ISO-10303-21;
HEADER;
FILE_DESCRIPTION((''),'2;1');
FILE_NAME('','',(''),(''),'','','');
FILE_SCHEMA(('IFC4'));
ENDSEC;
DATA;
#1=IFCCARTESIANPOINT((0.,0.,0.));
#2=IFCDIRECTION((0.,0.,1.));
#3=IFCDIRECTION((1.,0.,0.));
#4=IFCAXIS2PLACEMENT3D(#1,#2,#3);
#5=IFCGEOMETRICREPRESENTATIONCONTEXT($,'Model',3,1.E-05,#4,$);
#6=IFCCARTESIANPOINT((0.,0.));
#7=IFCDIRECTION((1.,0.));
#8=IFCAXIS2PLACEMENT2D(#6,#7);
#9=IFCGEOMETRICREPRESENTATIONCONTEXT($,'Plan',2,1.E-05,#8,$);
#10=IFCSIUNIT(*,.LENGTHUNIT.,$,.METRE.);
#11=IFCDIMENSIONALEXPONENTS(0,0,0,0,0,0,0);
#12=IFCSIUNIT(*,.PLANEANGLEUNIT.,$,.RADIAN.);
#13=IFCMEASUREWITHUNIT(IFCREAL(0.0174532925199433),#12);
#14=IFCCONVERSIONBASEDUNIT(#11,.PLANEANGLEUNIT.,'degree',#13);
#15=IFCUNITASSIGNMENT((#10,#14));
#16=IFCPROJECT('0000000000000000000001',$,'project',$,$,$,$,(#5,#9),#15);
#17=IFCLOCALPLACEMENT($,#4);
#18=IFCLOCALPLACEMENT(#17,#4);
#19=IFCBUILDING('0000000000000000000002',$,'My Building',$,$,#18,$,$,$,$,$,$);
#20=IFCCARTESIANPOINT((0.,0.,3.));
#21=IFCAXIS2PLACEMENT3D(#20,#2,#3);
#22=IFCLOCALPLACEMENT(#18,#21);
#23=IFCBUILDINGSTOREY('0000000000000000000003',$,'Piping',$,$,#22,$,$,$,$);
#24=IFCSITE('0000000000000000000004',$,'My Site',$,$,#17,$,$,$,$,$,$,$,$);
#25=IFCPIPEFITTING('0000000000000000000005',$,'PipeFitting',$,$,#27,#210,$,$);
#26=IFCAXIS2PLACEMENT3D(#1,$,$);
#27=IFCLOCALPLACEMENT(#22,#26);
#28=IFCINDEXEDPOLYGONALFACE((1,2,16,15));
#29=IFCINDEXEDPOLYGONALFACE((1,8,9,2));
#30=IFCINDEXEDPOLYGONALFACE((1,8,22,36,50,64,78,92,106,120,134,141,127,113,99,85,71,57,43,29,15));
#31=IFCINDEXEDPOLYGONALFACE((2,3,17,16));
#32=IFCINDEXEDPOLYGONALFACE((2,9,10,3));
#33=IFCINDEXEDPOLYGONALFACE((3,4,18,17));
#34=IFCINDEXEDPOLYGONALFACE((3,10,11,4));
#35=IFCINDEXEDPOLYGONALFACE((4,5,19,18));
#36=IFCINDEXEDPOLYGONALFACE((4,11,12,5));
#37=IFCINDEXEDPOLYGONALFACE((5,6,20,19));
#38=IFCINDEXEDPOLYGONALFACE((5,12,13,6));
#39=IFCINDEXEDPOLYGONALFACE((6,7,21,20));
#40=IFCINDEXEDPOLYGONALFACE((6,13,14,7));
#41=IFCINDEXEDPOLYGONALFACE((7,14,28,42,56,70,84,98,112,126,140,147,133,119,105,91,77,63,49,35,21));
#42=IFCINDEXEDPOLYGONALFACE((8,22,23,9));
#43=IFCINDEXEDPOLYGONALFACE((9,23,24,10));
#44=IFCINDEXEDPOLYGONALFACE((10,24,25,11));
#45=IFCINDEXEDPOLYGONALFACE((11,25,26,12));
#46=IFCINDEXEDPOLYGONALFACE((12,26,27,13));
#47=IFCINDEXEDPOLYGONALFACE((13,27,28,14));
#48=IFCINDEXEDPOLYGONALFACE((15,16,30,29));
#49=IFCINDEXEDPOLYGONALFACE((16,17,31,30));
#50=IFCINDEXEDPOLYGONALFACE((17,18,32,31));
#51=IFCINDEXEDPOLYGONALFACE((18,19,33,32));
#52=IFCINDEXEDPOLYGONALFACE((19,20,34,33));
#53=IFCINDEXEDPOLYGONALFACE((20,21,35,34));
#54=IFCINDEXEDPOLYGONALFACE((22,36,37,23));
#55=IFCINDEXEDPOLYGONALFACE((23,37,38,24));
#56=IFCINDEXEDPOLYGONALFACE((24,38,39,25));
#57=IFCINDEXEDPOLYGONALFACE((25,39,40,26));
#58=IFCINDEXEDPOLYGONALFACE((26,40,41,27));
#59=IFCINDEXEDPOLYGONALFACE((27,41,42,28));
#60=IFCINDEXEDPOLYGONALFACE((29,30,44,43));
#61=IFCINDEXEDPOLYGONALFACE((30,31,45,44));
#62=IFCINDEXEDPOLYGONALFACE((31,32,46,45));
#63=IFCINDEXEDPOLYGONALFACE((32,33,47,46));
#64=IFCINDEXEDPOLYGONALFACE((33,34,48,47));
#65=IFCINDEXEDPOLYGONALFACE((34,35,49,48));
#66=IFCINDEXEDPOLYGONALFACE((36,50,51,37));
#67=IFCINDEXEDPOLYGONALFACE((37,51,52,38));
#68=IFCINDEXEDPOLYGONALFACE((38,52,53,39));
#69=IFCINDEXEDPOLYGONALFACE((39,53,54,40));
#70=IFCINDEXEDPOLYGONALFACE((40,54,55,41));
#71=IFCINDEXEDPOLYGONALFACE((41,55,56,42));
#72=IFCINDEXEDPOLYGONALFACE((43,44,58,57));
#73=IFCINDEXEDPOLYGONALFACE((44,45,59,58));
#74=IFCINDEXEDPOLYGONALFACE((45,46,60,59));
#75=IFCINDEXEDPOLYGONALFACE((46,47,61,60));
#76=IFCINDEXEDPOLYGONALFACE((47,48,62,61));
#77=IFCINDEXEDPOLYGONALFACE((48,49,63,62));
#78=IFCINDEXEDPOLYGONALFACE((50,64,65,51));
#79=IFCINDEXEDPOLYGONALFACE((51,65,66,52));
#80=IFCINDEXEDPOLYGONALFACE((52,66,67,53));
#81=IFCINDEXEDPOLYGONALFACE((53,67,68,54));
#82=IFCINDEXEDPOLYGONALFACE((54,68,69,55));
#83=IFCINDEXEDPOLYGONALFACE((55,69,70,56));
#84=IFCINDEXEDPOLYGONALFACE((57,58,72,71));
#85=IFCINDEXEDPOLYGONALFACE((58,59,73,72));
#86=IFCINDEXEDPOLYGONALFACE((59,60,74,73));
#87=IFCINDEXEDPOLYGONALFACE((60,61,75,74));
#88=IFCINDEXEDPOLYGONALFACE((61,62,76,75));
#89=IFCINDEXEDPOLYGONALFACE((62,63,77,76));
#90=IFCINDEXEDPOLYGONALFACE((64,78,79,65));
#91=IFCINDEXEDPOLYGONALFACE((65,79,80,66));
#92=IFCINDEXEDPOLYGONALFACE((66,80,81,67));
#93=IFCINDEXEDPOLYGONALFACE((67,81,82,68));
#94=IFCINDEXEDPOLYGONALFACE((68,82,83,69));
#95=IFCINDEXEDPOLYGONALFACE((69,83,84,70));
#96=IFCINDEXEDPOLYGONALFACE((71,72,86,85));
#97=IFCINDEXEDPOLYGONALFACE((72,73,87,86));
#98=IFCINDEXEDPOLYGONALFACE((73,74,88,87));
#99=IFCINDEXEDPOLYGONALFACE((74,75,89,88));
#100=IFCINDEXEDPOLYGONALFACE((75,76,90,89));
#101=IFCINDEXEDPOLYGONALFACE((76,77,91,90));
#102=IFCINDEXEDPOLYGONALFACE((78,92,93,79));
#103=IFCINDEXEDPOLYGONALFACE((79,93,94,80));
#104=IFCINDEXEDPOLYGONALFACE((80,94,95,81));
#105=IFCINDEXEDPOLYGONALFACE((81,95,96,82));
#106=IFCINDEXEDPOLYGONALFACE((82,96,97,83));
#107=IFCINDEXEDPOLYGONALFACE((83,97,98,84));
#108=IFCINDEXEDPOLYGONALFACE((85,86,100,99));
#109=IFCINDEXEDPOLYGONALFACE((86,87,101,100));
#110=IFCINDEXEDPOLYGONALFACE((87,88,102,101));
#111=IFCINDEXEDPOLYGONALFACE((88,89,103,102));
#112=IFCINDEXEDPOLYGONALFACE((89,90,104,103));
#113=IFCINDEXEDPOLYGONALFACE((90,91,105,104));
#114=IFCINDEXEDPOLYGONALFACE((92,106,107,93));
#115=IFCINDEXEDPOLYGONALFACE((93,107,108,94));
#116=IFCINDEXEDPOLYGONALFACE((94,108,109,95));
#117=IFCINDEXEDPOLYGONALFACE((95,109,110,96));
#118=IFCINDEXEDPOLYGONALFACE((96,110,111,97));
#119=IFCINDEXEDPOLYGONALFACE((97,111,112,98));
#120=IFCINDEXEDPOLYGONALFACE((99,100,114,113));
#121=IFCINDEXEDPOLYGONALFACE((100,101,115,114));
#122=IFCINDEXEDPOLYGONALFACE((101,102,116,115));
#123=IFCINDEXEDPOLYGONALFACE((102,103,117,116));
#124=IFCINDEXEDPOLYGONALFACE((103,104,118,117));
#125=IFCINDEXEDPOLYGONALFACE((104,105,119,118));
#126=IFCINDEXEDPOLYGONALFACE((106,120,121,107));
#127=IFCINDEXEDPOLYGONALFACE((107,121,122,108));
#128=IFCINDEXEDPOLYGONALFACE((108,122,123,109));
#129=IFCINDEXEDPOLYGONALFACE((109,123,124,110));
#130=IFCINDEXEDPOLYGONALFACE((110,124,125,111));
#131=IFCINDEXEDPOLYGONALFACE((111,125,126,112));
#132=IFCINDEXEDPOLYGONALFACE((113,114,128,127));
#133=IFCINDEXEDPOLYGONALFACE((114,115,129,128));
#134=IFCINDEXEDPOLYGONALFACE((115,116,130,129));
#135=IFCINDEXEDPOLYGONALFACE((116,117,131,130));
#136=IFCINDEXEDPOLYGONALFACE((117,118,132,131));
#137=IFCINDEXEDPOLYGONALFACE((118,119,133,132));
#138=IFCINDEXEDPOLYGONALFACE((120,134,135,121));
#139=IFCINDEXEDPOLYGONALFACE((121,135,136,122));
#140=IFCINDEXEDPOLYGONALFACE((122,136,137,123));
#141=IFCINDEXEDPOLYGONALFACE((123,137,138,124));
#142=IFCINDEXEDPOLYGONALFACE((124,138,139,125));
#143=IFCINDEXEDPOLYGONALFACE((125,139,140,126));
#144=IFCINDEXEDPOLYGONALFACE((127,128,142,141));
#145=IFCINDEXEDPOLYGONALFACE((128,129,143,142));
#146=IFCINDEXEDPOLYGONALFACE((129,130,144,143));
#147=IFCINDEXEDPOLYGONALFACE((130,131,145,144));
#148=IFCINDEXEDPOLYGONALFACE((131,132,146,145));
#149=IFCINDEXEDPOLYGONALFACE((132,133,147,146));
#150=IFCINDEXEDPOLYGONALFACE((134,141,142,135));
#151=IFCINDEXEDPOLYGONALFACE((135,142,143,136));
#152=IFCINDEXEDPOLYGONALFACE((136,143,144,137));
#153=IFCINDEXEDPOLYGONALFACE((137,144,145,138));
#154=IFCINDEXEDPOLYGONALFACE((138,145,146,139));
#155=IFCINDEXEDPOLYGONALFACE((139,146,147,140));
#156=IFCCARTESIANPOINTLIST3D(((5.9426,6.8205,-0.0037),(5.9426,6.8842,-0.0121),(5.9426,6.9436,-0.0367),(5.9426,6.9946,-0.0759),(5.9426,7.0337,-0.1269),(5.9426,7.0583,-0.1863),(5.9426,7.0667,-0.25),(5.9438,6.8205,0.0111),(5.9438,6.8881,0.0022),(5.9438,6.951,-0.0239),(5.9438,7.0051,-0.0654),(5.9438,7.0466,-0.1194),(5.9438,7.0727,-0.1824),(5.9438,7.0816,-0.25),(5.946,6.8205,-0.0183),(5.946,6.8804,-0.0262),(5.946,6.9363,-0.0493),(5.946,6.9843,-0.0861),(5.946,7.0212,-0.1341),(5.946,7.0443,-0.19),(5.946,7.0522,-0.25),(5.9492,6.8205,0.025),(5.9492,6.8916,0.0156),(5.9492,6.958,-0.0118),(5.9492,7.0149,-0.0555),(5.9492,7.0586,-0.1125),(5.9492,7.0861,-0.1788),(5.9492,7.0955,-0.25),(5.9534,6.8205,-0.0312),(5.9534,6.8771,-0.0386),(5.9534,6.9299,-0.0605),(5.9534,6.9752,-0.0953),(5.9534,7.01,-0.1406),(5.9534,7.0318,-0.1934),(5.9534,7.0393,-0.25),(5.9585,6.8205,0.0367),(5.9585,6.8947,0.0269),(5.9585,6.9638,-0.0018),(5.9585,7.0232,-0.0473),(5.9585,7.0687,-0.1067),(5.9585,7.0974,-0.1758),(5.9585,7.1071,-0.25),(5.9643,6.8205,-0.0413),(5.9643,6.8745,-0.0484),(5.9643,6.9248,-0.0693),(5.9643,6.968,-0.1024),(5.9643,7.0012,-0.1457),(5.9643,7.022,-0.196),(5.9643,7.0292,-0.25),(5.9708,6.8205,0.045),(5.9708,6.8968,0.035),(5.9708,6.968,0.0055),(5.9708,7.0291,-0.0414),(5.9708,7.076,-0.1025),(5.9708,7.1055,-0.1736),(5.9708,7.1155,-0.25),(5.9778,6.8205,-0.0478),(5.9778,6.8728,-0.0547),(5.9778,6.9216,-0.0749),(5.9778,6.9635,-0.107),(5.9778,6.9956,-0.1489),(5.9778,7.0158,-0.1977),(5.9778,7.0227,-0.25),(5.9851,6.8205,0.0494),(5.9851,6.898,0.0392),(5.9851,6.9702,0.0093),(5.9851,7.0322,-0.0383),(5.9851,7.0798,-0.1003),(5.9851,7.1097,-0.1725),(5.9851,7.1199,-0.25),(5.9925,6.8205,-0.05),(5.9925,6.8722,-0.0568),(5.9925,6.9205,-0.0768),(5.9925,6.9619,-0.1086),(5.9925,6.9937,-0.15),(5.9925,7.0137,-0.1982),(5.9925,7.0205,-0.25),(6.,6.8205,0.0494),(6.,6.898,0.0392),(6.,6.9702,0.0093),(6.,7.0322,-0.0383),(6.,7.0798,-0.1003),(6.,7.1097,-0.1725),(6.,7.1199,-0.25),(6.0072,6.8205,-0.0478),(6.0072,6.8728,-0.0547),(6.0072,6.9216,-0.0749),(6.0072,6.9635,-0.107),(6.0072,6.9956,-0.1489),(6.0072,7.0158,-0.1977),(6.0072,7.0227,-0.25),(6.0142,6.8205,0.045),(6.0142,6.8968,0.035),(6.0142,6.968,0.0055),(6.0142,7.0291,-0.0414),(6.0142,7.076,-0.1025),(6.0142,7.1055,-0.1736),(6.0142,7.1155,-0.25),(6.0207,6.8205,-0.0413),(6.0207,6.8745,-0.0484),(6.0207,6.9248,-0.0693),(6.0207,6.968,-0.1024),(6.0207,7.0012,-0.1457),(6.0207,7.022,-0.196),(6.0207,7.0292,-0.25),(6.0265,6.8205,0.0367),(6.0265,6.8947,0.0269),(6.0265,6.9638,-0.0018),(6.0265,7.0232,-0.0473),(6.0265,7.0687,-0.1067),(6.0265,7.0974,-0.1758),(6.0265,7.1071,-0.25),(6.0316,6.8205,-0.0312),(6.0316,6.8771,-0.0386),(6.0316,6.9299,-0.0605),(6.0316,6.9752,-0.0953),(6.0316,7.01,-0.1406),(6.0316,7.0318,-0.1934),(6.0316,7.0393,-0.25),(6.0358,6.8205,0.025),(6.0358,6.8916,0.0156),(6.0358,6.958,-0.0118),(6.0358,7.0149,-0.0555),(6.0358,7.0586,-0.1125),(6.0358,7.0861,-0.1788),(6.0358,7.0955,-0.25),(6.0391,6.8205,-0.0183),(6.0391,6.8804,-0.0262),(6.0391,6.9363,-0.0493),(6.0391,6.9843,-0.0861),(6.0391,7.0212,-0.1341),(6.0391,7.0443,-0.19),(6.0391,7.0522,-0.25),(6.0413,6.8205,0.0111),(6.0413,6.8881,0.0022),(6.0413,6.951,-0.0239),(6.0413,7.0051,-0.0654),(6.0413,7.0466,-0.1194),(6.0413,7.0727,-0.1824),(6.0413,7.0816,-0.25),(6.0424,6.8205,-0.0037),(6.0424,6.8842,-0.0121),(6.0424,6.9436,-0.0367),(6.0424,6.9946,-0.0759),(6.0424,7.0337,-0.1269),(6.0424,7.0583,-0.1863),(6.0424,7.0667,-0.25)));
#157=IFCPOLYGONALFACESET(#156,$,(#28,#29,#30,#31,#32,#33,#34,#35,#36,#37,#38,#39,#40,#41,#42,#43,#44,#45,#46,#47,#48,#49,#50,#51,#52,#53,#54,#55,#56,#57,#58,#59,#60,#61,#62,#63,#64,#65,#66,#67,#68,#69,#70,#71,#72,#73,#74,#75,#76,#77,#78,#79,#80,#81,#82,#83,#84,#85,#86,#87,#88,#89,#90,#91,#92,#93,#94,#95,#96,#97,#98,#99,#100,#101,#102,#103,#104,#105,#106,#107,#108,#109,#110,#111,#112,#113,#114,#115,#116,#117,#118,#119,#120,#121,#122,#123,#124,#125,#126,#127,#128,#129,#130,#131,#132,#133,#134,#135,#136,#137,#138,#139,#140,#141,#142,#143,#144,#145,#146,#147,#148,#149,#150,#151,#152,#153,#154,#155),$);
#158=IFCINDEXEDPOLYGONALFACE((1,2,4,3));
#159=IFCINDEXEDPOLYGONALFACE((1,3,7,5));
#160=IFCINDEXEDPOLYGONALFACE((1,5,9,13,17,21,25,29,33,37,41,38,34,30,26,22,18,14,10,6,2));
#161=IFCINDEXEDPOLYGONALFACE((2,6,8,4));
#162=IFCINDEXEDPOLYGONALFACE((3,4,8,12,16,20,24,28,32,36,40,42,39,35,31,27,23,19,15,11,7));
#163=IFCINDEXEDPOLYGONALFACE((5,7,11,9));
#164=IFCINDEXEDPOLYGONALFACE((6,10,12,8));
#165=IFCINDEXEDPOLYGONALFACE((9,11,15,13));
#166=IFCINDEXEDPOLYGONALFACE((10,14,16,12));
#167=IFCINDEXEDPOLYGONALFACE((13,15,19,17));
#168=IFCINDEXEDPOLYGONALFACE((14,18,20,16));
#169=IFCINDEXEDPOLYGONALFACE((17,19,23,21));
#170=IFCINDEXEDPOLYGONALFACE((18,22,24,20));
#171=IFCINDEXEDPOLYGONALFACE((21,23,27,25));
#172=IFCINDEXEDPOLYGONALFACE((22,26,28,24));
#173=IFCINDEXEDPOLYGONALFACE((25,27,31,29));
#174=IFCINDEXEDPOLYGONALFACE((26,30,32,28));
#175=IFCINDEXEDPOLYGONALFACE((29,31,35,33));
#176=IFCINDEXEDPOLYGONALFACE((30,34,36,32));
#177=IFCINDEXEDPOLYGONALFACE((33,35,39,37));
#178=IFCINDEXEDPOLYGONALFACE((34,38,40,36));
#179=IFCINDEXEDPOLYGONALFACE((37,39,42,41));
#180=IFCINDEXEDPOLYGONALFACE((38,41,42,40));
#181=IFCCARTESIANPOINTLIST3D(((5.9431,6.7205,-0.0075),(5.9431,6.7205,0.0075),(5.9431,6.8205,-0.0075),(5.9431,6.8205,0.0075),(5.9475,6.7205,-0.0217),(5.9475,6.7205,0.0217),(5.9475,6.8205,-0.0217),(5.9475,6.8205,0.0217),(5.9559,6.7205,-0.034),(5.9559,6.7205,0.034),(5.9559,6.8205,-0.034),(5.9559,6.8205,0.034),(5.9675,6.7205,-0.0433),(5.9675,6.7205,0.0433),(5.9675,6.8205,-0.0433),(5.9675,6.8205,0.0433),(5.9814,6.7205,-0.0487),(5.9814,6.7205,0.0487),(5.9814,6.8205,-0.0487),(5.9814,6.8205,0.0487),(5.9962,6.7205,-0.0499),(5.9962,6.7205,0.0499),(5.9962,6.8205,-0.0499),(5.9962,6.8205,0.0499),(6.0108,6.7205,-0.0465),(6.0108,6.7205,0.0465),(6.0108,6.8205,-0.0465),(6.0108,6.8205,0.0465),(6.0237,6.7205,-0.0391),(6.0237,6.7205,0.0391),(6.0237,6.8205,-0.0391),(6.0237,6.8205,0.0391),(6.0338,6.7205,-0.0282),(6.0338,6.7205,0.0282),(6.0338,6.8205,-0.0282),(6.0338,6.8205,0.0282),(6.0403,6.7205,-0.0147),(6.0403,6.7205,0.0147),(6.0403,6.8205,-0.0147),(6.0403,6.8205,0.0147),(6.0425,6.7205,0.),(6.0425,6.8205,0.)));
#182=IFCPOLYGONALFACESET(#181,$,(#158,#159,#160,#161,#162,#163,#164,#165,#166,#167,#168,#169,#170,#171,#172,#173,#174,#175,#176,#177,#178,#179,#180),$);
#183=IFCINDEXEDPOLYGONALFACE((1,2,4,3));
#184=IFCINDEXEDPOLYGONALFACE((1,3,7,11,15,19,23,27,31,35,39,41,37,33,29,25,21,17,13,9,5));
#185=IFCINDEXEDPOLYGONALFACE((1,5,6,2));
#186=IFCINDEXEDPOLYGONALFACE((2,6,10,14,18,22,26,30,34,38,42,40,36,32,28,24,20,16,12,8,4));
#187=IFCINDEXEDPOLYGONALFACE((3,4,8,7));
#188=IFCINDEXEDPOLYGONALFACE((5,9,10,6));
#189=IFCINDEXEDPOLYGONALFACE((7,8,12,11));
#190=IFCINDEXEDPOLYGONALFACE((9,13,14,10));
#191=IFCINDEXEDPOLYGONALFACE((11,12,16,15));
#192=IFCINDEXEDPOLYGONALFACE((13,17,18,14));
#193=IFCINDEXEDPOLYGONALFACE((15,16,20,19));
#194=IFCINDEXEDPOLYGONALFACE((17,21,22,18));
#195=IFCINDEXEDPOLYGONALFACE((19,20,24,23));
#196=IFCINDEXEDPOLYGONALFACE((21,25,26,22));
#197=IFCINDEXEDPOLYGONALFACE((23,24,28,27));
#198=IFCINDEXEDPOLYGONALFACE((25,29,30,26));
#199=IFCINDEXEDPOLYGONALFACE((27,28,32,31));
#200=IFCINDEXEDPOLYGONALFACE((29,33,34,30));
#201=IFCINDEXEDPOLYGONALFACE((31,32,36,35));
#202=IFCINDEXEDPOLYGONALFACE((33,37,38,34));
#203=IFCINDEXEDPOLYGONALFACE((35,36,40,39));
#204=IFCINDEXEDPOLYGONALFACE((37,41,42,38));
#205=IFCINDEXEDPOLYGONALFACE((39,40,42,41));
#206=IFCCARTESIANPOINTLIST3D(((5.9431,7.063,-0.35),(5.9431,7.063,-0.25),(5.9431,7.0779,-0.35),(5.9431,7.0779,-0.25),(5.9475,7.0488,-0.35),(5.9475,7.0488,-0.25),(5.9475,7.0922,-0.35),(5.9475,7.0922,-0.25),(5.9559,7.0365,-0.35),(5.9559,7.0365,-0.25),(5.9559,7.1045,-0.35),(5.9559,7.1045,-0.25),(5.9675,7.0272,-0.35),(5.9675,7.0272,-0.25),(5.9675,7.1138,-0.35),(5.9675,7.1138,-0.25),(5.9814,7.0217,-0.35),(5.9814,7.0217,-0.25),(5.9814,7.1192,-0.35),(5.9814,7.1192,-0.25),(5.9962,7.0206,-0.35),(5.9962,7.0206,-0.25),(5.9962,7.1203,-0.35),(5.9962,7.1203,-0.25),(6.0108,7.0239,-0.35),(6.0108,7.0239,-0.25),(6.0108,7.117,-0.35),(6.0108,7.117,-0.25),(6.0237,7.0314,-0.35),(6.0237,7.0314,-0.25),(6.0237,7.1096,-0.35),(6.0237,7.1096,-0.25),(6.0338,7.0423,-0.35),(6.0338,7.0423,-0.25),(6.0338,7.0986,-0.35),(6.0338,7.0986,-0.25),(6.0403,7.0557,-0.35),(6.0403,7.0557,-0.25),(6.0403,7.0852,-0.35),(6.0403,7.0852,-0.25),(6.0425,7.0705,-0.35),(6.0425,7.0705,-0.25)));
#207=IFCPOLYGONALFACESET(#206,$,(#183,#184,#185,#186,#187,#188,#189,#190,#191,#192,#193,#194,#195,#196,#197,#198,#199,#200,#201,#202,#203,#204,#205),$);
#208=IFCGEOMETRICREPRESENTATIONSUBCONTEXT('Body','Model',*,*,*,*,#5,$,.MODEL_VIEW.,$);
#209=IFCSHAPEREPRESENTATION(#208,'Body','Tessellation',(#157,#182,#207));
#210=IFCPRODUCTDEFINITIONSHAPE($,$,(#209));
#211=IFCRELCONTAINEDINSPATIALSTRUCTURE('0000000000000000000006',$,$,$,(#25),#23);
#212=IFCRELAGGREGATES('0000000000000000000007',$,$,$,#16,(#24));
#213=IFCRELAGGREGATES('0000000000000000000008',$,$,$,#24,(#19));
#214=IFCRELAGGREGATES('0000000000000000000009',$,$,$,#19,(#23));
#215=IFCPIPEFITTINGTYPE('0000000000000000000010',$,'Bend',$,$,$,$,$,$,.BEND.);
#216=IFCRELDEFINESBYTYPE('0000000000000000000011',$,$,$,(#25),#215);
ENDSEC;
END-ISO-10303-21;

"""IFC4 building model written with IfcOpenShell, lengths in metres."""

from ifc_helpers import new_model, entity, si_unit, converted_unit, frame, origin_with_axes, origin_2d_with_axis, place, context, subcontext, project, spatial, circle, extrude, source, transform, mapped, type_object, type_shapes, element, save


model = new_model("IFC4")

# Units and contexts
model_context = context("Model", 3, precision=1e-05, world=origin_with_axes())
plan_context = context("Plan", 2, precision=1e-05, world=origin_2d_with_axis())
body_context = subcontext(model_context, "Body", "Model", "MODEL_VIEW")
ifc_project = project(units=[si_unit("LENGTHUNIT", "METRE"), converted_unit("PLANEANGLEUNIT", "degree", entity("IfcReal", 0.0174532925199433), si_unit("PLANEANGLEUNIT", "RADIAN"), dimensions=[0, 0, 0, 0, 0, 0, 0])], contexts=[model_context, plan_context])

# Site, building, storey
site_placement = place(None, origin_with_axes())
site = spatial("IfcSite", under=ifc_project, at=site_placement, Name="My Site")
building_placement = place(site_placement, origin_with_axes())
building = spatial("IfcBuilding", under=site, at=building_placement, Name="My Building")
storey_placement = place(building_placement, frame((0.0, 0.0, 3.0), z_axis=(0.0, 0.0, 1.0), x_axis=(1.0, 0.0, 0.0)))
storey = spatial("IfcBuildingStorey", under=building, at=storey_placement, Name="Piping")

# Pipe fitting
pipe_fitting_type = type_object("IfcPipeFittingType", Name="Bend", PredefinedType="BEND")
shared_shape = source(origin_with_axes(), body_context, "Body", "SolidModel", [
    entity("IfcSweptDiskSolid", entity("IfcIndexedPolyCurve", entity("IfcCartesianPointList3D", [[0.0, 0.0, -0.1], [0.0, -0.0732, -0.2768], [0.0, -0.25, -0.35]]), [entity("IfcArcIndex", [1, 2, 3])]), 0.05),
    extrude(circle(Radius=0.05), origin_with_axes(), (0.0, 0.0, -1.0), 0.1),
    extrude(circle(Radius=0.05), frame((0.0, -0.25, -0.35), z_axis=(0.0, -1.0, 0.0), x_axis=(1.0, 0.0, 0.0)), (0.0, 0.0, 1.0), 0.1),
])
type_shapes(pipe_fitting_type, [shared_shape])
for number, where, z_axis, x_axis, name in (
    (1, (5.9925, 6.7205, 0.0), (0.0, -1.0, 0.0), (1.0, 0.0, 0.0), "PipeFitting"),
):
    element("IfcPipeFitting", number, at=place(storey_placement, frame(where, z_axis=z_axis, x_axis=x_axis)), inside=storey, type_object=pipe_fitting_type, Name=name, context=body_context, shape_type="MappedRepresentation", body=[
        mapped(shared_shape, transform((0.0, 0.0, 0.0), x_axis=(1.0, 0.0, 0.0), y_axis=(0.0, 1.0, 0.0), z_axis=(0.0, 0.0, 1.0), scale=1.0)),
    ])

save(model, "model.ifc")
